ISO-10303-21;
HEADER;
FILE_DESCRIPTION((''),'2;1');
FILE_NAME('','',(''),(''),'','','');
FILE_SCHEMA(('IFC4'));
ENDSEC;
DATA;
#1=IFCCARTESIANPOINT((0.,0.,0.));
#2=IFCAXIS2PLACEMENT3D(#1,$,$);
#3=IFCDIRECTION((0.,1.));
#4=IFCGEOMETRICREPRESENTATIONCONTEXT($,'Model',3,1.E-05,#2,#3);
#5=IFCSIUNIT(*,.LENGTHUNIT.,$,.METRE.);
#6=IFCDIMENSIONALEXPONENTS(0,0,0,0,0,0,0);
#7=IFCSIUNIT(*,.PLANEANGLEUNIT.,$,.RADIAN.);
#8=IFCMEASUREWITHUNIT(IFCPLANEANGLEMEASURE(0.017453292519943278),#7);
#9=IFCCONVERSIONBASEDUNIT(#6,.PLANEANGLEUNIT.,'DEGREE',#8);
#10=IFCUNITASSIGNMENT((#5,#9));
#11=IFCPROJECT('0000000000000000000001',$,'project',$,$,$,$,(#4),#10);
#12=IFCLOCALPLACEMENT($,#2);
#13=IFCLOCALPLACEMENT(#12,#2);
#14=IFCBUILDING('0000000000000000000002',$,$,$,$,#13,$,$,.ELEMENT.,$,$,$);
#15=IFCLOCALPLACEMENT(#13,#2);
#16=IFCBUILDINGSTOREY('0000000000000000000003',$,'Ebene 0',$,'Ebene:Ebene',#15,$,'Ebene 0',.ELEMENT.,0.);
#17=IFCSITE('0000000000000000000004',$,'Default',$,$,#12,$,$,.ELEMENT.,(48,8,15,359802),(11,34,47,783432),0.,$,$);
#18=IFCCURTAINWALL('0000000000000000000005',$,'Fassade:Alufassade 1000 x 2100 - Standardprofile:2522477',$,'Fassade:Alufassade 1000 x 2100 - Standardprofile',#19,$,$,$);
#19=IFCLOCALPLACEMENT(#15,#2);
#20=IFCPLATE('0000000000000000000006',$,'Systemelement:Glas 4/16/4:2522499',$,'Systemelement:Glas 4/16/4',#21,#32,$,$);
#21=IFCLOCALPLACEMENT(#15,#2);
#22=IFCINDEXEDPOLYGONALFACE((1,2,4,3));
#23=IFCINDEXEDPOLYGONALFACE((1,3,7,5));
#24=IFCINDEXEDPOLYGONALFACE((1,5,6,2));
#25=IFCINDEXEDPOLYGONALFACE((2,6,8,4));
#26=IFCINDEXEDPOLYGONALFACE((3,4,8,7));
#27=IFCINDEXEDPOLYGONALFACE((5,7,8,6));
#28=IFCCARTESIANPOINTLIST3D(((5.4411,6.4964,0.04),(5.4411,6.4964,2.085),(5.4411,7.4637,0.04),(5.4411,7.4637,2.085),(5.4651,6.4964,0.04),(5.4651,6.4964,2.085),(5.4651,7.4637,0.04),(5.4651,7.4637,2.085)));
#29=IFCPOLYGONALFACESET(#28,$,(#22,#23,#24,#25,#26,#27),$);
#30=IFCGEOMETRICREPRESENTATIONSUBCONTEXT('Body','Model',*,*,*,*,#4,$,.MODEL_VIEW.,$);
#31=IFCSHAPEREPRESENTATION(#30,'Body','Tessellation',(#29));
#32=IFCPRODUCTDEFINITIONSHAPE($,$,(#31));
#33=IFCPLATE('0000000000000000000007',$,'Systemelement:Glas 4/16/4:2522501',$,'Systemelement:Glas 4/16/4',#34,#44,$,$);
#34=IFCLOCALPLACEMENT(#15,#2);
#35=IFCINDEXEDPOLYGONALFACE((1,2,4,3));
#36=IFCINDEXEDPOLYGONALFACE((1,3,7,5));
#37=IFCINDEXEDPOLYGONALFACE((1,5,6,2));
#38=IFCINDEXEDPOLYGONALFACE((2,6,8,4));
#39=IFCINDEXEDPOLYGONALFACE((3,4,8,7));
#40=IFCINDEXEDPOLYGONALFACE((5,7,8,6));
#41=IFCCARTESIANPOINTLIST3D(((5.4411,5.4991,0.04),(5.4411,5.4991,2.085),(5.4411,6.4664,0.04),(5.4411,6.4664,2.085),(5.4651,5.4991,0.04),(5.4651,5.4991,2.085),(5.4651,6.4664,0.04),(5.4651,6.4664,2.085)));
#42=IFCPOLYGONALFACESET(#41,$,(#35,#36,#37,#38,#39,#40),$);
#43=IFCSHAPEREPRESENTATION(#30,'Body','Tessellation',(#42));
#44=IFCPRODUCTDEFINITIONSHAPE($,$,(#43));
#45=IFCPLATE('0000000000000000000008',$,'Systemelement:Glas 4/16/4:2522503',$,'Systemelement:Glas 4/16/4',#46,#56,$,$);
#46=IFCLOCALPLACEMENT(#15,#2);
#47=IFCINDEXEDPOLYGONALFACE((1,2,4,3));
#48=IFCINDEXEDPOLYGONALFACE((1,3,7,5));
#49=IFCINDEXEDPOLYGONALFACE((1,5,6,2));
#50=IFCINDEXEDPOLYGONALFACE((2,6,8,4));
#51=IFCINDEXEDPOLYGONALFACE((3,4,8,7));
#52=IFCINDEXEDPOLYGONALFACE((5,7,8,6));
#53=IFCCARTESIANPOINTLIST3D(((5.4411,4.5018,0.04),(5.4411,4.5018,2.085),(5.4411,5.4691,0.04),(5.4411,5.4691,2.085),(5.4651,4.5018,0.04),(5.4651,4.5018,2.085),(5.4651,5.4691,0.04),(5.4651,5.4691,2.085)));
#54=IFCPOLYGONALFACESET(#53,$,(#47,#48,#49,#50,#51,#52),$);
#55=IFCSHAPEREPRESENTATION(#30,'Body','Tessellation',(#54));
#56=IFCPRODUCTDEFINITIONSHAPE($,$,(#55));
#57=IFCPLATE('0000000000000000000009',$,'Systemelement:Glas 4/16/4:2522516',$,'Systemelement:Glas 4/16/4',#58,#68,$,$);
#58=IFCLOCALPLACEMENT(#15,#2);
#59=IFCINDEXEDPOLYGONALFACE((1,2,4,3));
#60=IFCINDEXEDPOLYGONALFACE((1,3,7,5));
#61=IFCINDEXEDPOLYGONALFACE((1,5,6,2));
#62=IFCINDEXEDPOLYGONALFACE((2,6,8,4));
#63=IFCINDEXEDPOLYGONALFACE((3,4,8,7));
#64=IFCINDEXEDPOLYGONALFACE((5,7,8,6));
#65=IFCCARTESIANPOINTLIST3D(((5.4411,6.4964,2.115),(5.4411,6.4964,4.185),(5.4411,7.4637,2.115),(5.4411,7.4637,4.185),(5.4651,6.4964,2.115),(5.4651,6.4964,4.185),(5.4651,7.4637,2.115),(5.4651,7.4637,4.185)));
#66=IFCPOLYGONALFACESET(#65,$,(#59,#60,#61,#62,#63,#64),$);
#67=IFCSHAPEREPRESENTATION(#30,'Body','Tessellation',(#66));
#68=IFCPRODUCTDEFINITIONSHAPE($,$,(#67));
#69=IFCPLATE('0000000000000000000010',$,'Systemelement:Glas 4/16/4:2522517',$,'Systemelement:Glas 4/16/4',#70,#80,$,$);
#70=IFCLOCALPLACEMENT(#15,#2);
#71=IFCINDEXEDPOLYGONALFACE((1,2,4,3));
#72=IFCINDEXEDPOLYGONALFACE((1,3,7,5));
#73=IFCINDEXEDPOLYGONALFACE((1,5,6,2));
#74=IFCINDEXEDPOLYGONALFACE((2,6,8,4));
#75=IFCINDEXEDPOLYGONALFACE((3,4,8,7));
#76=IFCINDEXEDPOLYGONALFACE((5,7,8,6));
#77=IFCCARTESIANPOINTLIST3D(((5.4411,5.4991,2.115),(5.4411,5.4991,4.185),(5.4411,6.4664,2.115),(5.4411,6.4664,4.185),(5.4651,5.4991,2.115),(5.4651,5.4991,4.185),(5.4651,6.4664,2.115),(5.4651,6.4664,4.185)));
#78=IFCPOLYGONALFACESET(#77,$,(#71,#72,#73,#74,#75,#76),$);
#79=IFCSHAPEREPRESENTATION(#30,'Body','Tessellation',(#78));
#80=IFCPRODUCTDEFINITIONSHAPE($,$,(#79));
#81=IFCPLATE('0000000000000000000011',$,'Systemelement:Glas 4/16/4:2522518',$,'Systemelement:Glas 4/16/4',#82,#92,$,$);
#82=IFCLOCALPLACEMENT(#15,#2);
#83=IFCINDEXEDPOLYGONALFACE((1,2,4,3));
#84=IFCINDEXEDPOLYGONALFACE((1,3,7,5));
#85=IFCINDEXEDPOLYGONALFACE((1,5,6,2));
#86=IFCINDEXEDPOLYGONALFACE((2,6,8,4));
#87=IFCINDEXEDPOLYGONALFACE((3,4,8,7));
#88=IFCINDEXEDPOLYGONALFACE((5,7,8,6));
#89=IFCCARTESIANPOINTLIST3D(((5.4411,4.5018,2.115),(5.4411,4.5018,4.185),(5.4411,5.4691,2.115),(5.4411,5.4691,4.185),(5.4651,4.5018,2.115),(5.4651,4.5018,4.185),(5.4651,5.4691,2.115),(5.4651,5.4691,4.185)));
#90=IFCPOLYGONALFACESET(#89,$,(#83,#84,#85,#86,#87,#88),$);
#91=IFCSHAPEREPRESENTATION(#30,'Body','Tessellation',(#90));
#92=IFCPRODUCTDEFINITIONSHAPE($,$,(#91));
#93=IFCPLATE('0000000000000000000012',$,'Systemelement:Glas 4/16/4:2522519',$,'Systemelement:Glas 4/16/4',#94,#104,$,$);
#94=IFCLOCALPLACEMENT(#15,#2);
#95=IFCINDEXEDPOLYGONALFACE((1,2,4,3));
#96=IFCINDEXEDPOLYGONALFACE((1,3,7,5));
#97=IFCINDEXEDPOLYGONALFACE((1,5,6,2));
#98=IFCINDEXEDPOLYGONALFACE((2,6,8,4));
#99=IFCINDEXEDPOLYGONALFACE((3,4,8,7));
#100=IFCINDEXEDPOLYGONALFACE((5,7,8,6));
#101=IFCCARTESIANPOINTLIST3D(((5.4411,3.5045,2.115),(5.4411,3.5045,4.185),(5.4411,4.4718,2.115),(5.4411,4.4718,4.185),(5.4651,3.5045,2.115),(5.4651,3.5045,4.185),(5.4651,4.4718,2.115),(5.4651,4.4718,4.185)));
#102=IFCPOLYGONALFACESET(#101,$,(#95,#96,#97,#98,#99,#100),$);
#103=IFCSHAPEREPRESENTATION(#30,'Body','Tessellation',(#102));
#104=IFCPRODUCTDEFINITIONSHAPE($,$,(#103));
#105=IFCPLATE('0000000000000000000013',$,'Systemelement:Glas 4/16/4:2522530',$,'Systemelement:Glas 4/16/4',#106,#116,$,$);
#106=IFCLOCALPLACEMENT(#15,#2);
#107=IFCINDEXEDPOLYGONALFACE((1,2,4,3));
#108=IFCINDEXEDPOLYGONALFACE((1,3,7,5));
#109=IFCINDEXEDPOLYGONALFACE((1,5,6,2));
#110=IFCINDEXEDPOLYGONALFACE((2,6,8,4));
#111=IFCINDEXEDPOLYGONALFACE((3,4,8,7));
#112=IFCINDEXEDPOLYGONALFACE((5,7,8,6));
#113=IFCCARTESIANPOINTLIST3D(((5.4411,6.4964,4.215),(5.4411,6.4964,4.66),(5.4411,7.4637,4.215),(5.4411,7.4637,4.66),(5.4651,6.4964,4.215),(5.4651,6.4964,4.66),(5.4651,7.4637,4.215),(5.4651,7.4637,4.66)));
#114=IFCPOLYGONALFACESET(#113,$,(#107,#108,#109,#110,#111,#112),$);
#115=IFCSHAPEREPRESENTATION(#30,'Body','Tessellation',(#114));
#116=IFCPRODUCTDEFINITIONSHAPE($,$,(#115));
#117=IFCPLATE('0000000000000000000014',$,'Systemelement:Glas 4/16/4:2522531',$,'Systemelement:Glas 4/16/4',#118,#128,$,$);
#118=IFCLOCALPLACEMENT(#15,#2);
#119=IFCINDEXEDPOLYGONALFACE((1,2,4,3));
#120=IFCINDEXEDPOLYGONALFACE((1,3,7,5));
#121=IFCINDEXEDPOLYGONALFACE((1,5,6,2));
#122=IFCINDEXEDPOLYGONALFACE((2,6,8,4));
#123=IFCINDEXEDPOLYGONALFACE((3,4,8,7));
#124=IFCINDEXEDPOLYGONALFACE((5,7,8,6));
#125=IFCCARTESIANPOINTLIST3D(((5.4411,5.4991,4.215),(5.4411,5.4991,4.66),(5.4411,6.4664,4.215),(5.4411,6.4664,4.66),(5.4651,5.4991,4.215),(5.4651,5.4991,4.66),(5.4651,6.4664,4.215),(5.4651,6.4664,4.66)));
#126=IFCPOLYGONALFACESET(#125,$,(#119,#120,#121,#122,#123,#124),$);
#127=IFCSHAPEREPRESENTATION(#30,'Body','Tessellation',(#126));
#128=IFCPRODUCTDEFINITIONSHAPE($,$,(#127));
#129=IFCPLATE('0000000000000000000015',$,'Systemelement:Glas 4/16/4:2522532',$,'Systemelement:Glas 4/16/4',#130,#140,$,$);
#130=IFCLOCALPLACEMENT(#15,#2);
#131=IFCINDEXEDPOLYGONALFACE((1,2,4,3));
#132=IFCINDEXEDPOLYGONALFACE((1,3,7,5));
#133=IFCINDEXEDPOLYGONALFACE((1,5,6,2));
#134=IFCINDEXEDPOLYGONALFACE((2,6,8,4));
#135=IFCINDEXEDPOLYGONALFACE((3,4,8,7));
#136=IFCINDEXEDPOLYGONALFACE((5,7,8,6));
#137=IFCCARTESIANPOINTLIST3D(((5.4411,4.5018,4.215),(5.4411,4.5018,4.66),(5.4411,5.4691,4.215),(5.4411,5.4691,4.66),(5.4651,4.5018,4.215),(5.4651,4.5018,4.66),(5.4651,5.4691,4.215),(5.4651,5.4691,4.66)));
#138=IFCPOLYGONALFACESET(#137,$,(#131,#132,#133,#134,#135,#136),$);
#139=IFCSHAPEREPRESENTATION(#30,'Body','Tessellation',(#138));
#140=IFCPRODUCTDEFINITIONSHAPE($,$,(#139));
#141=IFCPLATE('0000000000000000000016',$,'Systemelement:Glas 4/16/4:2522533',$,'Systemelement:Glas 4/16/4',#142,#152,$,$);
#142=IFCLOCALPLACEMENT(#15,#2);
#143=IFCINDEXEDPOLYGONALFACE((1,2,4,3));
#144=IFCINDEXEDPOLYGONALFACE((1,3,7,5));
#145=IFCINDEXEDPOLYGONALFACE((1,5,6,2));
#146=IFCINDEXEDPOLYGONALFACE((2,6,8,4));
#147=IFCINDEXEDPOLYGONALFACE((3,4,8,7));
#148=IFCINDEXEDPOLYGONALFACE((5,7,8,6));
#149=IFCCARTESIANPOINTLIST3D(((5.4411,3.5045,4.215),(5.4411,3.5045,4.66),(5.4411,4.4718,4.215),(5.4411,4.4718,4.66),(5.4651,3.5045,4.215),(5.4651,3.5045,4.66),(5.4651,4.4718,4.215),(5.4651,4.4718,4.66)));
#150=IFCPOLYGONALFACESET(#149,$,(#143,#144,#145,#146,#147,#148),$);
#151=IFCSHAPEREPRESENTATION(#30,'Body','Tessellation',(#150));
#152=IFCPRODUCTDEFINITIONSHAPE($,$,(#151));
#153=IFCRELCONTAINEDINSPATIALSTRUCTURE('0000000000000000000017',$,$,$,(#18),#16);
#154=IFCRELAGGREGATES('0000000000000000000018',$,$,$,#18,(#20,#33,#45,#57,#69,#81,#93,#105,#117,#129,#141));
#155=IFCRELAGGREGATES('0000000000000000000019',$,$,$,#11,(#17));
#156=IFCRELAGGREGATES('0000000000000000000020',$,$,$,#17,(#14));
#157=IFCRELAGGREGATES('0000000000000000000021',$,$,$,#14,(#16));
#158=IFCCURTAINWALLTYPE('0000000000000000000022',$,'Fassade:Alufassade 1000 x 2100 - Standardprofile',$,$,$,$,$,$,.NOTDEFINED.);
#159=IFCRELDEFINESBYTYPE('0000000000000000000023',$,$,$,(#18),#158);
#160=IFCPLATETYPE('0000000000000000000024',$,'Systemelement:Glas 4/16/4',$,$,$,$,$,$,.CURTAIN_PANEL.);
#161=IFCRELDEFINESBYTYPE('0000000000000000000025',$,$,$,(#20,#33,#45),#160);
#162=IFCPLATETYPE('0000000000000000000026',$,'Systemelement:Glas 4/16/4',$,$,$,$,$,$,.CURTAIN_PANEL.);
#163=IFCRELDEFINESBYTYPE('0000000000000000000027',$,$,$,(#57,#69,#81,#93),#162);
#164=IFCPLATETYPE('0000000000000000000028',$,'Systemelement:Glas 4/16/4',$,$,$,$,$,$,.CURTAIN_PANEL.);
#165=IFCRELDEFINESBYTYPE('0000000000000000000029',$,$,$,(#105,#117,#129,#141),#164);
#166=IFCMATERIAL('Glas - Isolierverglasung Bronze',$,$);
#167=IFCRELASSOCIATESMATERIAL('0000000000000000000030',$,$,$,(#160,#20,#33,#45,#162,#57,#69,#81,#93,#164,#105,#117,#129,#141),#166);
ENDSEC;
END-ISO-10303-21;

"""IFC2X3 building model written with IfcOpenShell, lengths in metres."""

from ifc_helpers import new_model, entity, si_unit, converted_unit, direction, frame, origin, origin_2d_with_axis, place, context, subcontext, project, spatial, rectangle, extrude, source, transform, mapped, material, type_object, type_shapes, element, aggregate, save


model = new_model("IFC2X3")

# Units and contexts
model_context = context("Model", 3, precision=1e-05, world=origin(), true_north=direction((0.0, 1.0)))
body_context = subcontext(model_context, "Body", "Model", "MODEL_VIEW")
ifc_project = project(units=[si_unit("LENGTHUNIT", "METRE"), converted_unit("PLANEANGLEUNIT", "DEGREE", entity("IfcPlaneAngleMeasure", 0.017453292519943278), si_unit("PLANEANGLEUNIT", "RADIAN"), dimensions=[0, 0, 0, 0, 0, 0, 0])], contexts=[model_context])

# Site, building, storey
site_placement = place(None, origin())
site = spatial("IfcSite", under=ifc_project, at=site_placement, Name="Default", CompositionType="ELEMENT", RefLatitude=(48, 8, 15, 359802), RefLongitude=(11, 34, 47, 783432), RefElevation=0.0)
building_placement = place(site_placement, origin())
building = spatial("IfcBuilding", under=site, at=building_placement, CompositionType="ELEMENT")
storey_placement = place(building_placement, origin())
storey = spatial("IfcBuildingStorey", under=building, at=storey_placement, Name="Ebene 0", ObjectType="Ebene:Ebene", LongName="Ebene 0", CompositionType="ELEMENT", Elevation=0.0)

# Curtain wall, plates
curtain_wall_type = type_object("IfcCurtainWallType", Name="Fassade:Alufassade 1000 x 2100 - Standardprofile", PredefinedType="NOTDEFINED")
curtain_wall_placement = place(storey_placement, origin())
curtain_wall = element("IfcCurtainWall", 1, at=curtain_wall_placement, inside=storey, type_object=curtain_wall_type, Name="Fassade:Alufassade 1000 x 2100 - Standardprofile:2522477", ObjectType="Fassade:Alufassade 1000 x 2100 - Standardprofile")
ifc_material_1 = material(Name="Glas - Isolierverglasung Bronze")
plate_type_1 = type_object("IfcPlateType", Name="Systemelement:Glas 4/16/4", PredefinedType="CURTAIN_PANEL", material=ifc_material_1)
shared_shape_1 = source(origin(), body_context, "Body", "SweptSolid", [
    extrude(rectangle(XDim=0.024, YDim=0.9673, at=origin_2d_with_axis()), frame((0.0, 0.0, 0.0), z_axis=(0.0, 0.0, 1.0), x_axis=(0.0, 1.0, 0.0)), (0.0, 0.0, 1.0), 2.045),
])
type_shapes(plate_type_1, [shared_shape_1])
plate_1_placement = place(curtain_wall_placement, frame((5.4531, 6.9801, 0.04), z_axis=(0.0, 0.0, 1.0), x_axis=(0.0, -1.0, 0.0)))
plate_1 = element("IfcPlate", 2, at=plate_1_placement, type_object=plate_type_1, material=ifc_material_1, Name="Systemelement:Glas 4/16/4:2522499", ObjectType="Systemelement:Glas 4/16/4", context=body_context, shape_type="MappedRepresentation", body=[
    mapped(shared_shape_1, transform((0.0, 0.0, 0.0), scale=1.0)),
])
plate_2_placement = place(curtain_wall_placement, frame((5.4531, 5.9828, 0.04), z_axis=(0.0, 0.0, 1.0), x_axis=(0.0, -1.0, 0.0)))
plate_2 = element("IfcPlate", 3, at=plate_2_placement, type_object=plate_type_1, material=ifc_material_1, Name="Systemelement:Glas 4/16/4:2522501", ObjectType="Systemelement:Glas 4/16/4", context=body_context, shape_type="MappedRepresentation", body=[
    mapped(shared_shape_1, transform((0.0, 0.0, 0.0), scale=1.0)),
])
plate_3_placement = place(curtain_wall_placement, frame((5.4531, 4.9855, 0.04), z_axis=(0.0, 0.0, 1.0), x_axis=(0.0, -1.0, 0.0)))
plate_3 = element("IfcPlate", 4, at=plate_3_placement, type_object=plate_type_1, material=ifc_material_1, Name="Systemelement:Glas 4/16/4:2522503", ObjectType="Systemelement:Glas 4/16/4", context=body_context, shape_type="MappedRepresentation", body=[
    mapped(shared_shape_1, transform((0.0, 0.0, 0.0), scale=1.0)),
])
plate_type_2 = type_object("IfcPlateType", Name="Systemelement:Glas 4/16/4", PredefinedType="CURTAIN_PANEL", material=ifc_material_1)
shared_shape_2 = source(origin(), body_context, "Body", "SweptSolid", [
    extrude(rectangle(XDim=0.024, YDim=0.9673, at=origin_2d_with_axis()), frame((0.0, 0.0, 0.0), z_axis=(0.0, 0.0, 1.0), x_axis=(0.0, 1.0, 0.0)), (0.0, 0.0, 1.0), 2.07),
])
type_shapes(plate_type_2, [shared_shape_2])
plate_4_placement = place(curtain_wall_placement, frame((5.4531, 6.9801, 2.115), z_axis=(0.0, 0.0, 1.0), x_axis=(0.0, -1.0, 0.0)))
plate_4 = element("IfcPlate", 5, at=plate_4_placement, type_object=plate_type_2, material=ifc_material_1, Name="Systemelement:Glas 4/16/4:2522516", ObjectType="Systemelement:Glas 4/16/4", context=body_context, shape_type="MappedRepresentation", body=[
    mapped(shared_shape_2, transform((0.0, 0.0, 0.0), scale=1.0)),
])
plate_5_placement = place(curtain_wall_placement, frame((5.4531, 5.9828, 2.115), z_axis=(0.0, 0.0, 1.0), x_axis=(0.0, -1.0, 0.0)))
plate_5 = element("IfcPlate", 6, at=plate_5_placement, type_object=plate_type_2, material=ifc_material_1, Name="Systemelement:Glas 4/16/4:2522517", ObjectType="Systemelement:Glas 4/16/4", context=body_context, shape_type="MappedRepresentation", body=[
    mapped(shared_shape_2, transform((0.0, 0.0, 0.0), scale=1.0)),
])
plate_6_placement = place(curtain_wall_placement, frame((5.4531, 4.9855, 2.115), z_axis=(0.0, 0.0, 1.0), x_axis=(0.0, -1.0, 0.0)))
plate_6 = element("IfcPlate", 7, at=plate_6_placement, type_object=plate_type_2, material=ifc_material_1, Name="Systemelement:Glas 4/16/4:2522518", ObjectType="Systemelement:Glas 4/16/4", context=body_context, shape_type="MappedRepresentation", body=[
    mapped(shared_shape_2, transform((0.0, 0.0, 0.0), scale=1.0)),
])
plate_7_placement = place(curtain_wall_placement, frame((5.4531, 3.9882, 2.115), z_axis=(0.0, 0.0, 1.0), x_axis=(0.0, -1.0, 0.0)))
plate_7 = element("IfcPlate", 8, at=plate_7_placement, type_object=plate_type_2, material=ifc_material_1, Name="Systemelement:Glas 4/16/4:2522519", ObjectType="Systemelement:Glas 4/16/4", context=body_context, shape_type="MappedRepresentation", body=[
    mapped(shared_shape_2, transform((0.0, 0.0, 0.0), scale=1.0)),
])
plate_type_3 = type_object("IfcPlateType", Name="Systemelement:Glas 4/16/4", PredefinedType="CURTAIN_PANEL", material=ifc_material_1)
shared_shape_3 = source(origin(), body_context, "Body", "SweptSolid", [
    extrude(rectangle(XDim=0.024, YDim=0.9673, at=origin_2d_with_axis()), frame((0.0, 0.0, 0.0), z_axis=(0.0, 0.0, 1.0), x_axis=(0.0, 1.0, 0.0)), (0.0, 0.0, 1.0), 0.445),
])
type_shapes(plate_type_3, [shared_shape_3])
plate_8_placement = place(curtain_wall_placement, frame((5.4531, 6.9801, 4.215), z_axis=(0.0, 0.0, 1.0), x_axis=(0.0, -1.0, 0.0)))
plate_8 = element("IfcPlate", 9, at=plate_8_placement, type_object=plate_type_3, material=ifc_material_1, Name="Systemelement:Glas 4/16/4:2522530", ObjectType="Systemelement:Glas 4/16/4", context=body_context, shape_type="MappedRepresentation", body=[
    mapped(shared_shape_3, transform((0.0, 0.0, 0.0), scale=1.0)),
])
plate_9_placement = place(curtain_wall_placement, frame((5.4531, 5.9828, 4.215), z_axis=(0.0, 0.0, 1.0), x_axis=(0.0, -1.0, 0.0)))
plate_9 = element("IfcPlate", 10, at=plate_9_placement, type_object=plate_type_3, material=ifc_material_1, Name="Systemelement:Glas 4/16/4:2522531", ObjectType="Systemelement:Glas 4/16/4", context=body_context, shape_type="MappedRepresentation", body=[
    mapped(shared_shape_3, transform((0.0, 0.0, 0.0), scale=1.0)),
])
plate_10_placement = place(curtain_wall_placement, frame((5.4531, 4.9855, 4.215), z_axis=(0.0, 0.0, 1.0), x_axis=(0.0, -1.0, 0.0)))
plate_10 = element("IfcPlate", 11, at=plate_10_placement, type_object=plate_type_3, material=ifc_material_1, Name="Systemelement:Glas 4/16/4:2522532", ObjectType="Systemelement:Glas 4/16/4", context=body_context, shape_type="MappedRepresentation", body=[
    mapped(shared_shape_3, transform((0.0, 0.0, 0.0), scale=1.0)),
])
plate_11_placement = place(curtain_wall_placement, frame((5.4531, 3.9882, 4.215), z_axis=(0.0, 0.0, 1.0), x_axis=(0.0, -1.0, 0.0)))
plate_11 = element("IfcPlate", 12, at=plate_11_placement, type_object=plate_type_3, material=ifc_material_1, Name="Systemelement:Glas 4/16/4:2522533", ObjectType="Systemelement:Glas 4/16/4", context=body_context, shape_type="MappedRepresentation", body=[
    mapped(shared_shape_3, transform((0.0, 0.0, 0.0), scale=1.0)),
])
aggregate(curtain_wall, [plate_1, plate_2, plate_3, plate_4, plate_5, plate_6, plate_7, plate_8, plate_9, plate_10, plate_11])

save(model, "model.ifc")
